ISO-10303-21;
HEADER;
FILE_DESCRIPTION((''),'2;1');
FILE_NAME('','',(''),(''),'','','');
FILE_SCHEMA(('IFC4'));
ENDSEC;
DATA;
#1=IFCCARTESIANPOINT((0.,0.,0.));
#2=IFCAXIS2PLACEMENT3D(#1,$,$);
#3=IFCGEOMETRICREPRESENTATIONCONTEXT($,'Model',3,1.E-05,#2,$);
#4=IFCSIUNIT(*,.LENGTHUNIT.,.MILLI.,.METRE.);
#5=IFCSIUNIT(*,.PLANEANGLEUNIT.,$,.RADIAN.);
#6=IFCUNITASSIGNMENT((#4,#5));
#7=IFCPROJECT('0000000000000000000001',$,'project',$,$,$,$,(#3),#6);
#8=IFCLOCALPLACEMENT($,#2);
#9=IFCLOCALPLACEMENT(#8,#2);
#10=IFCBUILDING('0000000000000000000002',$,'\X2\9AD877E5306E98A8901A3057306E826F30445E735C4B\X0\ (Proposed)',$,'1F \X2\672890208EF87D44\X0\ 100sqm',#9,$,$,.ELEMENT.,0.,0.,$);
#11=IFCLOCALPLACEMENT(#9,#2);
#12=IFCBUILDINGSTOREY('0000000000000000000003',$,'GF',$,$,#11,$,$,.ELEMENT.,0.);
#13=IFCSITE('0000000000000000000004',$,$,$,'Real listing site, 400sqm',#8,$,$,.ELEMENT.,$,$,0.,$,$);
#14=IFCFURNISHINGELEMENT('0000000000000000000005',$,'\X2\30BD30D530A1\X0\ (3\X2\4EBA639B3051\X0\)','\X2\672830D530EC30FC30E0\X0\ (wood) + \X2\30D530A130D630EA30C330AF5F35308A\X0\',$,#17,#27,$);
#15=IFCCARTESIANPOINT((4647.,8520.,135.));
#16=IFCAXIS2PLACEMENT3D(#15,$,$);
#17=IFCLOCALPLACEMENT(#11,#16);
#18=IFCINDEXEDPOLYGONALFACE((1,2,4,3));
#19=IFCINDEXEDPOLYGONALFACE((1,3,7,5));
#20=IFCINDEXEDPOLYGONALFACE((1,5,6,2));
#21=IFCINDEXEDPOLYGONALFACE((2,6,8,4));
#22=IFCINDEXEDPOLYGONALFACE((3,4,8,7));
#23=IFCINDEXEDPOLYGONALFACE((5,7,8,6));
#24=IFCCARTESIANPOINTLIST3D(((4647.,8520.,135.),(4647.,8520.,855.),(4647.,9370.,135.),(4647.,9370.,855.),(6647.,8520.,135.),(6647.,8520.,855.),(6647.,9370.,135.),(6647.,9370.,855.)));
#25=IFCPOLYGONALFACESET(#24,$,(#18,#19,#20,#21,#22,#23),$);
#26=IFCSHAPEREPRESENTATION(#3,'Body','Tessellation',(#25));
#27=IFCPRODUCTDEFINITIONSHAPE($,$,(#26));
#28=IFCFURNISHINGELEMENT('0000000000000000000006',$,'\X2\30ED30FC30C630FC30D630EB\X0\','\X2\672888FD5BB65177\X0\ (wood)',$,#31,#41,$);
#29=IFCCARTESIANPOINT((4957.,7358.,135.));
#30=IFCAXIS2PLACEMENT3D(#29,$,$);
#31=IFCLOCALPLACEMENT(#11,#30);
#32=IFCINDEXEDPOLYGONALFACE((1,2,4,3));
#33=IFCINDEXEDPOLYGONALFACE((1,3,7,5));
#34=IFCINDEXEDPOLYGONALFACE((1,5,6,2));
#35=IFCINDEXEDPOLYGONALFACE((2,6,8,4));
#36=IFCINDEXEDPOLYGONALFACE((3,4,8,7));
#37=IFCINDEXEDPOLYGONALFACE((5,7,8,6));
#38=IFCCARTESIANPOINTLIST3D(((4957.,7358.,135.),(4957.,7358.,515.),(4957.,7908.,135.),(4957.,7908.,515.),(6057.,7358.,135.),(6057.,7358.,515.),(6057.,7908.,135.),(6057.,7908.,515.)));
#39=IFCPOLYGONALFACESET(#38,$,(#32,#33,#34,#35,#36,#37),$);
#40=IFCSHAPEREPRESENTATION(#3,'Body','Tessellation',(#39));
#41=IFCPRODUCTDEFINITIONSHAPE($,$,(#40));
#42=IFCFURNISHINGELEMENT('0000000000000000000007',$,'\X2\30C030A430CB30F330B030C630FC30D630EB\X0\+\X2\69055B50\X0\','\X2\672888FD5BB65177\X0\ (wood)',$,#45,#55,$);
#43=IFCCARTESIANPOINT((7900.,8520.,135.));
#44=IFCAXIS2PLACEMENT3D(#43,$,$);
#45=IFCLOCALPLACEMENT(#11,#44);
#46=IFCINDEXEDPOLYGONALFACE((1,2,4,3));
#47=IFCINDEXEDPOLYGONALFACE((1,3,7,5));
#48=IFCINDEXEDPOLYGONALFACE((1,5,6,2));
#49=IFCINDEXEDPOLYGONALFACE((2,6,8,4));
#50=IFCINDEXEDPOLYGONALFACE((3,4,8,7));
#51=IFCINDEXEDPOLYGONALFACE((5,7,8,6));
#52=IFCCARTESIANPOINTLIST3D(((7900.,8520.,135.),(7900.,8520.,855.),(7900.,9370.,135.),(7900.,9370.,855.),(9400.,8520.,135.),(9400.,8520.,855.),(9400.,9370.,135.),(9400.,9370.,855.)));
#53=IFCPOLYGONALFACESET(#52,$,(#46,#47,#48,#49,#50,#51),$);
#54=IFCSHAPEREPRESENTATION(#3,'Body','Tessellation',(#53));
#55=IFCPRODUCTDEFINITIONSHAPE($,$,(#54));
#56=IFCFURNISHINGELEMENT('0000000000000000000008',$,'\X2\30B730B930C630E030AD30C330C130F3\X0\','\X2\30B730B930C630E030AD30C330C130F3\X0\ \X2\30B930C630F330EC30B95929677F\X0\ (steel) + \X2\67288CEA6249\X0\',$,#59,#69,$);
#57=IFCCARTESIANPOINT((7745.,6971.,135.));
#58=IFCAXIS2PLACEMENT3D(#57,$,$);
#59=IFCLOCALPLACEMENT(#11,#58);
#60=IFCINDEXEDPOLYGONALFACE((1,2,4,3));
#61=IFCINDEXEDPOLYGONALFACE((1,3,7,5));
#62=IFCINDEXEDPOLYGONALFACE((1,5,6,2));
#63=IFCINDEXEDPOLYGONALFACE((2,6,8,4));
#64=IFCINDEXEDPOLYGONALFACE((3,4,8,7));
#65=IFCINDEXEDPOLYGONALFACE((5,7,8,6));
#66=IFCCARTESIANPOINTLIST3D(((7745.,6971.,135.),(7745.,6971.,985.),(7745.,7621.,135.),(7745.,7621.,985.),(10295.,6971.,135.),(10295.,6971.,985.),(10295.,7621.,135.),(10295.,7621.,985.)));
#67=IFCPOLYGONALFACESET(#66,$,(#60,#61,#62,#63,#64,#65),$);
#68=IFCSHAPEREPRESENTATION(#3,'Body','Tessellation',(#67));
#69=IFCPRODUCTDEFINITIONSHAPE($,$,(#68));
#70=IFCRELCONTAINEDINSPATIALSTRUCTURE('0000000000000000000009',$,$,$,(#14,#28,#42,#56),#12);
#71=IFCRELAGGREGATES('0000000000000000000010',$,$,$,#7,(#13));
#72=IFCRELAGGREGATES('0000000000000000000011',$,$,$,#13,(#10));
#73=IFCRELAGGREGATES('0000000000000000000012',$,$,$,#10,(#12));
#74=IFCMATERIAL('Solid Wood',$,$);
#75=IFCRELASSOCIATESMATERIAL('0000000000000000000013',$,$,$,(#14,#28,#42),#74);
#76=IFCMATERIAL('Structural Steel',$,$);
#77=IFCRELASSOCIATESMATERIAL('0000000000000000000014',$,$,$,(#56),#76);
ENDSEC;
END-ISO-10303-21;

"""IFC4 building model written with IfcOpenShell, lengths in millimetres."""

from ifc_helpers import new_model, si_unit, frame, frame_2d, origin, place, context, project, spatial, rectangle, extrude, material, element, save


model = new_model("IFC4")

# Units and contexts
model_context = context("Model", 3, precision=1e-05, world=origin())
ifc_project = project(units=[si_unit("LENGTHUNIT", "METRE", prefix="MILLI"), si_unit("PLANEANGLEUNIT", "RADIAN")], contexts=[model_context])

# Site, building, storey
site_placement = place(None, origin())
site = spatial("IfcSite", under=ifc_project, at=site_placement, ObjectType="Real listing site, 400sqm", CompositionType="ELEMENT", RefElevation=0.0)
building_placement = place(site_placement, origin())
building = spatial("IfcBuilding", under=site, at=building_placement, Name="高知の風通しの良い平屋 (Proposed)", ObjectType="1F 木造軸組 100sqm", CompositionType="ELEMENT", ElevationOfRefHeight=0.0, ElevationOfTerrain=0.0)
storey_placement = place(building_placement, origin())
storey = spatial("IfcBuildingStorey", under=building, at=storey_placement, Name="GF", CompositionType="ELEMENT", Elevation=0.0)

# Shared definitions
ifc_material_1 = material(Name="Solid Wood")

# Shared definitions
ifc_material_2 = material(Name="Structural Steel")

# Furnishing elements
furnishing_1_placement = place(storey_placement, frame((4647.0, 8520.0, 135.0)))
element("IfcFurnishingElement", 1, at=furnishing_1_placement, inside=storey, material=ifc_material_1, Name="ソファ (3人掛け)", Description="木フレーム (wood) + ファブリック張り", context=model_context, shape_type="SweptSolid", body=[
    extrude(rectangle(XDim=2000.0, YDim=850.0, at=frame_2d((1000.0, 425.0))), frame((4647.0, 8520.0, 135.0)), (0.0, 0.0, 1.0), 720.0),
])
furnishing_2_placement = place(storey_placement, frame((4957.0, 7358.0, 135.0)))
element("IfcFurnishingElement", 2, at=furnishing_2_placement, inside=storey, material=ifc_material_1, Name="ローテーブル", Description="木製家具 (wood)", context=model_context, shape_type="SweptSolid", body=[
    extrude(rectangle(XDim=1100.0, YDim=550.0, at=frame_2d((550.0, 275.0))), frame((4957.0, 7358.0, 135.0)), (0.0, 0.0, 1.0), 380.0),
])
furnishing_3_placement = place(storey_placement, frame((7900.0, 8520.0, 135.0)))
element("IfcFurnishingElement", 3, at=furnishing_3_placement, inside=storey, material=ifc_material_1, Name="ダイニングテーブル+椅子", Description="木製家具 (wood)", context=model_context, shape_type="SweptSolid", body=[
    extrude(rectangle(XDim=1500.0, YDim=850.0, at=frame_2d((750.0, 425.0))), frame((7900.0, 8520.0, 135.0)), (0.0, 0.0, 1.0), 720.0),
])
furnishing_4_placement = place(storey_placement, frame((7745.0, 6971.0, 135.0)))
element("IfcFurnishingElement", 4, at=furnishing_4_placement, inside=storey, material=ifc_material_2, Name="システムキッチン", Description="システムキッチン ステンレス天板 (steel) + 木質扉", context=model_context, shape_type="SweptSolid", body=[
    extrude(rectangle(XDim=2550.0, YDim=650.0, at=frame_2d((1275.0, 325.0))), frame((7745.0, 6971.0, 135.0)), (0.0, 0.0, 1.0), 850.0),
])

save(model, "model.ifc")
